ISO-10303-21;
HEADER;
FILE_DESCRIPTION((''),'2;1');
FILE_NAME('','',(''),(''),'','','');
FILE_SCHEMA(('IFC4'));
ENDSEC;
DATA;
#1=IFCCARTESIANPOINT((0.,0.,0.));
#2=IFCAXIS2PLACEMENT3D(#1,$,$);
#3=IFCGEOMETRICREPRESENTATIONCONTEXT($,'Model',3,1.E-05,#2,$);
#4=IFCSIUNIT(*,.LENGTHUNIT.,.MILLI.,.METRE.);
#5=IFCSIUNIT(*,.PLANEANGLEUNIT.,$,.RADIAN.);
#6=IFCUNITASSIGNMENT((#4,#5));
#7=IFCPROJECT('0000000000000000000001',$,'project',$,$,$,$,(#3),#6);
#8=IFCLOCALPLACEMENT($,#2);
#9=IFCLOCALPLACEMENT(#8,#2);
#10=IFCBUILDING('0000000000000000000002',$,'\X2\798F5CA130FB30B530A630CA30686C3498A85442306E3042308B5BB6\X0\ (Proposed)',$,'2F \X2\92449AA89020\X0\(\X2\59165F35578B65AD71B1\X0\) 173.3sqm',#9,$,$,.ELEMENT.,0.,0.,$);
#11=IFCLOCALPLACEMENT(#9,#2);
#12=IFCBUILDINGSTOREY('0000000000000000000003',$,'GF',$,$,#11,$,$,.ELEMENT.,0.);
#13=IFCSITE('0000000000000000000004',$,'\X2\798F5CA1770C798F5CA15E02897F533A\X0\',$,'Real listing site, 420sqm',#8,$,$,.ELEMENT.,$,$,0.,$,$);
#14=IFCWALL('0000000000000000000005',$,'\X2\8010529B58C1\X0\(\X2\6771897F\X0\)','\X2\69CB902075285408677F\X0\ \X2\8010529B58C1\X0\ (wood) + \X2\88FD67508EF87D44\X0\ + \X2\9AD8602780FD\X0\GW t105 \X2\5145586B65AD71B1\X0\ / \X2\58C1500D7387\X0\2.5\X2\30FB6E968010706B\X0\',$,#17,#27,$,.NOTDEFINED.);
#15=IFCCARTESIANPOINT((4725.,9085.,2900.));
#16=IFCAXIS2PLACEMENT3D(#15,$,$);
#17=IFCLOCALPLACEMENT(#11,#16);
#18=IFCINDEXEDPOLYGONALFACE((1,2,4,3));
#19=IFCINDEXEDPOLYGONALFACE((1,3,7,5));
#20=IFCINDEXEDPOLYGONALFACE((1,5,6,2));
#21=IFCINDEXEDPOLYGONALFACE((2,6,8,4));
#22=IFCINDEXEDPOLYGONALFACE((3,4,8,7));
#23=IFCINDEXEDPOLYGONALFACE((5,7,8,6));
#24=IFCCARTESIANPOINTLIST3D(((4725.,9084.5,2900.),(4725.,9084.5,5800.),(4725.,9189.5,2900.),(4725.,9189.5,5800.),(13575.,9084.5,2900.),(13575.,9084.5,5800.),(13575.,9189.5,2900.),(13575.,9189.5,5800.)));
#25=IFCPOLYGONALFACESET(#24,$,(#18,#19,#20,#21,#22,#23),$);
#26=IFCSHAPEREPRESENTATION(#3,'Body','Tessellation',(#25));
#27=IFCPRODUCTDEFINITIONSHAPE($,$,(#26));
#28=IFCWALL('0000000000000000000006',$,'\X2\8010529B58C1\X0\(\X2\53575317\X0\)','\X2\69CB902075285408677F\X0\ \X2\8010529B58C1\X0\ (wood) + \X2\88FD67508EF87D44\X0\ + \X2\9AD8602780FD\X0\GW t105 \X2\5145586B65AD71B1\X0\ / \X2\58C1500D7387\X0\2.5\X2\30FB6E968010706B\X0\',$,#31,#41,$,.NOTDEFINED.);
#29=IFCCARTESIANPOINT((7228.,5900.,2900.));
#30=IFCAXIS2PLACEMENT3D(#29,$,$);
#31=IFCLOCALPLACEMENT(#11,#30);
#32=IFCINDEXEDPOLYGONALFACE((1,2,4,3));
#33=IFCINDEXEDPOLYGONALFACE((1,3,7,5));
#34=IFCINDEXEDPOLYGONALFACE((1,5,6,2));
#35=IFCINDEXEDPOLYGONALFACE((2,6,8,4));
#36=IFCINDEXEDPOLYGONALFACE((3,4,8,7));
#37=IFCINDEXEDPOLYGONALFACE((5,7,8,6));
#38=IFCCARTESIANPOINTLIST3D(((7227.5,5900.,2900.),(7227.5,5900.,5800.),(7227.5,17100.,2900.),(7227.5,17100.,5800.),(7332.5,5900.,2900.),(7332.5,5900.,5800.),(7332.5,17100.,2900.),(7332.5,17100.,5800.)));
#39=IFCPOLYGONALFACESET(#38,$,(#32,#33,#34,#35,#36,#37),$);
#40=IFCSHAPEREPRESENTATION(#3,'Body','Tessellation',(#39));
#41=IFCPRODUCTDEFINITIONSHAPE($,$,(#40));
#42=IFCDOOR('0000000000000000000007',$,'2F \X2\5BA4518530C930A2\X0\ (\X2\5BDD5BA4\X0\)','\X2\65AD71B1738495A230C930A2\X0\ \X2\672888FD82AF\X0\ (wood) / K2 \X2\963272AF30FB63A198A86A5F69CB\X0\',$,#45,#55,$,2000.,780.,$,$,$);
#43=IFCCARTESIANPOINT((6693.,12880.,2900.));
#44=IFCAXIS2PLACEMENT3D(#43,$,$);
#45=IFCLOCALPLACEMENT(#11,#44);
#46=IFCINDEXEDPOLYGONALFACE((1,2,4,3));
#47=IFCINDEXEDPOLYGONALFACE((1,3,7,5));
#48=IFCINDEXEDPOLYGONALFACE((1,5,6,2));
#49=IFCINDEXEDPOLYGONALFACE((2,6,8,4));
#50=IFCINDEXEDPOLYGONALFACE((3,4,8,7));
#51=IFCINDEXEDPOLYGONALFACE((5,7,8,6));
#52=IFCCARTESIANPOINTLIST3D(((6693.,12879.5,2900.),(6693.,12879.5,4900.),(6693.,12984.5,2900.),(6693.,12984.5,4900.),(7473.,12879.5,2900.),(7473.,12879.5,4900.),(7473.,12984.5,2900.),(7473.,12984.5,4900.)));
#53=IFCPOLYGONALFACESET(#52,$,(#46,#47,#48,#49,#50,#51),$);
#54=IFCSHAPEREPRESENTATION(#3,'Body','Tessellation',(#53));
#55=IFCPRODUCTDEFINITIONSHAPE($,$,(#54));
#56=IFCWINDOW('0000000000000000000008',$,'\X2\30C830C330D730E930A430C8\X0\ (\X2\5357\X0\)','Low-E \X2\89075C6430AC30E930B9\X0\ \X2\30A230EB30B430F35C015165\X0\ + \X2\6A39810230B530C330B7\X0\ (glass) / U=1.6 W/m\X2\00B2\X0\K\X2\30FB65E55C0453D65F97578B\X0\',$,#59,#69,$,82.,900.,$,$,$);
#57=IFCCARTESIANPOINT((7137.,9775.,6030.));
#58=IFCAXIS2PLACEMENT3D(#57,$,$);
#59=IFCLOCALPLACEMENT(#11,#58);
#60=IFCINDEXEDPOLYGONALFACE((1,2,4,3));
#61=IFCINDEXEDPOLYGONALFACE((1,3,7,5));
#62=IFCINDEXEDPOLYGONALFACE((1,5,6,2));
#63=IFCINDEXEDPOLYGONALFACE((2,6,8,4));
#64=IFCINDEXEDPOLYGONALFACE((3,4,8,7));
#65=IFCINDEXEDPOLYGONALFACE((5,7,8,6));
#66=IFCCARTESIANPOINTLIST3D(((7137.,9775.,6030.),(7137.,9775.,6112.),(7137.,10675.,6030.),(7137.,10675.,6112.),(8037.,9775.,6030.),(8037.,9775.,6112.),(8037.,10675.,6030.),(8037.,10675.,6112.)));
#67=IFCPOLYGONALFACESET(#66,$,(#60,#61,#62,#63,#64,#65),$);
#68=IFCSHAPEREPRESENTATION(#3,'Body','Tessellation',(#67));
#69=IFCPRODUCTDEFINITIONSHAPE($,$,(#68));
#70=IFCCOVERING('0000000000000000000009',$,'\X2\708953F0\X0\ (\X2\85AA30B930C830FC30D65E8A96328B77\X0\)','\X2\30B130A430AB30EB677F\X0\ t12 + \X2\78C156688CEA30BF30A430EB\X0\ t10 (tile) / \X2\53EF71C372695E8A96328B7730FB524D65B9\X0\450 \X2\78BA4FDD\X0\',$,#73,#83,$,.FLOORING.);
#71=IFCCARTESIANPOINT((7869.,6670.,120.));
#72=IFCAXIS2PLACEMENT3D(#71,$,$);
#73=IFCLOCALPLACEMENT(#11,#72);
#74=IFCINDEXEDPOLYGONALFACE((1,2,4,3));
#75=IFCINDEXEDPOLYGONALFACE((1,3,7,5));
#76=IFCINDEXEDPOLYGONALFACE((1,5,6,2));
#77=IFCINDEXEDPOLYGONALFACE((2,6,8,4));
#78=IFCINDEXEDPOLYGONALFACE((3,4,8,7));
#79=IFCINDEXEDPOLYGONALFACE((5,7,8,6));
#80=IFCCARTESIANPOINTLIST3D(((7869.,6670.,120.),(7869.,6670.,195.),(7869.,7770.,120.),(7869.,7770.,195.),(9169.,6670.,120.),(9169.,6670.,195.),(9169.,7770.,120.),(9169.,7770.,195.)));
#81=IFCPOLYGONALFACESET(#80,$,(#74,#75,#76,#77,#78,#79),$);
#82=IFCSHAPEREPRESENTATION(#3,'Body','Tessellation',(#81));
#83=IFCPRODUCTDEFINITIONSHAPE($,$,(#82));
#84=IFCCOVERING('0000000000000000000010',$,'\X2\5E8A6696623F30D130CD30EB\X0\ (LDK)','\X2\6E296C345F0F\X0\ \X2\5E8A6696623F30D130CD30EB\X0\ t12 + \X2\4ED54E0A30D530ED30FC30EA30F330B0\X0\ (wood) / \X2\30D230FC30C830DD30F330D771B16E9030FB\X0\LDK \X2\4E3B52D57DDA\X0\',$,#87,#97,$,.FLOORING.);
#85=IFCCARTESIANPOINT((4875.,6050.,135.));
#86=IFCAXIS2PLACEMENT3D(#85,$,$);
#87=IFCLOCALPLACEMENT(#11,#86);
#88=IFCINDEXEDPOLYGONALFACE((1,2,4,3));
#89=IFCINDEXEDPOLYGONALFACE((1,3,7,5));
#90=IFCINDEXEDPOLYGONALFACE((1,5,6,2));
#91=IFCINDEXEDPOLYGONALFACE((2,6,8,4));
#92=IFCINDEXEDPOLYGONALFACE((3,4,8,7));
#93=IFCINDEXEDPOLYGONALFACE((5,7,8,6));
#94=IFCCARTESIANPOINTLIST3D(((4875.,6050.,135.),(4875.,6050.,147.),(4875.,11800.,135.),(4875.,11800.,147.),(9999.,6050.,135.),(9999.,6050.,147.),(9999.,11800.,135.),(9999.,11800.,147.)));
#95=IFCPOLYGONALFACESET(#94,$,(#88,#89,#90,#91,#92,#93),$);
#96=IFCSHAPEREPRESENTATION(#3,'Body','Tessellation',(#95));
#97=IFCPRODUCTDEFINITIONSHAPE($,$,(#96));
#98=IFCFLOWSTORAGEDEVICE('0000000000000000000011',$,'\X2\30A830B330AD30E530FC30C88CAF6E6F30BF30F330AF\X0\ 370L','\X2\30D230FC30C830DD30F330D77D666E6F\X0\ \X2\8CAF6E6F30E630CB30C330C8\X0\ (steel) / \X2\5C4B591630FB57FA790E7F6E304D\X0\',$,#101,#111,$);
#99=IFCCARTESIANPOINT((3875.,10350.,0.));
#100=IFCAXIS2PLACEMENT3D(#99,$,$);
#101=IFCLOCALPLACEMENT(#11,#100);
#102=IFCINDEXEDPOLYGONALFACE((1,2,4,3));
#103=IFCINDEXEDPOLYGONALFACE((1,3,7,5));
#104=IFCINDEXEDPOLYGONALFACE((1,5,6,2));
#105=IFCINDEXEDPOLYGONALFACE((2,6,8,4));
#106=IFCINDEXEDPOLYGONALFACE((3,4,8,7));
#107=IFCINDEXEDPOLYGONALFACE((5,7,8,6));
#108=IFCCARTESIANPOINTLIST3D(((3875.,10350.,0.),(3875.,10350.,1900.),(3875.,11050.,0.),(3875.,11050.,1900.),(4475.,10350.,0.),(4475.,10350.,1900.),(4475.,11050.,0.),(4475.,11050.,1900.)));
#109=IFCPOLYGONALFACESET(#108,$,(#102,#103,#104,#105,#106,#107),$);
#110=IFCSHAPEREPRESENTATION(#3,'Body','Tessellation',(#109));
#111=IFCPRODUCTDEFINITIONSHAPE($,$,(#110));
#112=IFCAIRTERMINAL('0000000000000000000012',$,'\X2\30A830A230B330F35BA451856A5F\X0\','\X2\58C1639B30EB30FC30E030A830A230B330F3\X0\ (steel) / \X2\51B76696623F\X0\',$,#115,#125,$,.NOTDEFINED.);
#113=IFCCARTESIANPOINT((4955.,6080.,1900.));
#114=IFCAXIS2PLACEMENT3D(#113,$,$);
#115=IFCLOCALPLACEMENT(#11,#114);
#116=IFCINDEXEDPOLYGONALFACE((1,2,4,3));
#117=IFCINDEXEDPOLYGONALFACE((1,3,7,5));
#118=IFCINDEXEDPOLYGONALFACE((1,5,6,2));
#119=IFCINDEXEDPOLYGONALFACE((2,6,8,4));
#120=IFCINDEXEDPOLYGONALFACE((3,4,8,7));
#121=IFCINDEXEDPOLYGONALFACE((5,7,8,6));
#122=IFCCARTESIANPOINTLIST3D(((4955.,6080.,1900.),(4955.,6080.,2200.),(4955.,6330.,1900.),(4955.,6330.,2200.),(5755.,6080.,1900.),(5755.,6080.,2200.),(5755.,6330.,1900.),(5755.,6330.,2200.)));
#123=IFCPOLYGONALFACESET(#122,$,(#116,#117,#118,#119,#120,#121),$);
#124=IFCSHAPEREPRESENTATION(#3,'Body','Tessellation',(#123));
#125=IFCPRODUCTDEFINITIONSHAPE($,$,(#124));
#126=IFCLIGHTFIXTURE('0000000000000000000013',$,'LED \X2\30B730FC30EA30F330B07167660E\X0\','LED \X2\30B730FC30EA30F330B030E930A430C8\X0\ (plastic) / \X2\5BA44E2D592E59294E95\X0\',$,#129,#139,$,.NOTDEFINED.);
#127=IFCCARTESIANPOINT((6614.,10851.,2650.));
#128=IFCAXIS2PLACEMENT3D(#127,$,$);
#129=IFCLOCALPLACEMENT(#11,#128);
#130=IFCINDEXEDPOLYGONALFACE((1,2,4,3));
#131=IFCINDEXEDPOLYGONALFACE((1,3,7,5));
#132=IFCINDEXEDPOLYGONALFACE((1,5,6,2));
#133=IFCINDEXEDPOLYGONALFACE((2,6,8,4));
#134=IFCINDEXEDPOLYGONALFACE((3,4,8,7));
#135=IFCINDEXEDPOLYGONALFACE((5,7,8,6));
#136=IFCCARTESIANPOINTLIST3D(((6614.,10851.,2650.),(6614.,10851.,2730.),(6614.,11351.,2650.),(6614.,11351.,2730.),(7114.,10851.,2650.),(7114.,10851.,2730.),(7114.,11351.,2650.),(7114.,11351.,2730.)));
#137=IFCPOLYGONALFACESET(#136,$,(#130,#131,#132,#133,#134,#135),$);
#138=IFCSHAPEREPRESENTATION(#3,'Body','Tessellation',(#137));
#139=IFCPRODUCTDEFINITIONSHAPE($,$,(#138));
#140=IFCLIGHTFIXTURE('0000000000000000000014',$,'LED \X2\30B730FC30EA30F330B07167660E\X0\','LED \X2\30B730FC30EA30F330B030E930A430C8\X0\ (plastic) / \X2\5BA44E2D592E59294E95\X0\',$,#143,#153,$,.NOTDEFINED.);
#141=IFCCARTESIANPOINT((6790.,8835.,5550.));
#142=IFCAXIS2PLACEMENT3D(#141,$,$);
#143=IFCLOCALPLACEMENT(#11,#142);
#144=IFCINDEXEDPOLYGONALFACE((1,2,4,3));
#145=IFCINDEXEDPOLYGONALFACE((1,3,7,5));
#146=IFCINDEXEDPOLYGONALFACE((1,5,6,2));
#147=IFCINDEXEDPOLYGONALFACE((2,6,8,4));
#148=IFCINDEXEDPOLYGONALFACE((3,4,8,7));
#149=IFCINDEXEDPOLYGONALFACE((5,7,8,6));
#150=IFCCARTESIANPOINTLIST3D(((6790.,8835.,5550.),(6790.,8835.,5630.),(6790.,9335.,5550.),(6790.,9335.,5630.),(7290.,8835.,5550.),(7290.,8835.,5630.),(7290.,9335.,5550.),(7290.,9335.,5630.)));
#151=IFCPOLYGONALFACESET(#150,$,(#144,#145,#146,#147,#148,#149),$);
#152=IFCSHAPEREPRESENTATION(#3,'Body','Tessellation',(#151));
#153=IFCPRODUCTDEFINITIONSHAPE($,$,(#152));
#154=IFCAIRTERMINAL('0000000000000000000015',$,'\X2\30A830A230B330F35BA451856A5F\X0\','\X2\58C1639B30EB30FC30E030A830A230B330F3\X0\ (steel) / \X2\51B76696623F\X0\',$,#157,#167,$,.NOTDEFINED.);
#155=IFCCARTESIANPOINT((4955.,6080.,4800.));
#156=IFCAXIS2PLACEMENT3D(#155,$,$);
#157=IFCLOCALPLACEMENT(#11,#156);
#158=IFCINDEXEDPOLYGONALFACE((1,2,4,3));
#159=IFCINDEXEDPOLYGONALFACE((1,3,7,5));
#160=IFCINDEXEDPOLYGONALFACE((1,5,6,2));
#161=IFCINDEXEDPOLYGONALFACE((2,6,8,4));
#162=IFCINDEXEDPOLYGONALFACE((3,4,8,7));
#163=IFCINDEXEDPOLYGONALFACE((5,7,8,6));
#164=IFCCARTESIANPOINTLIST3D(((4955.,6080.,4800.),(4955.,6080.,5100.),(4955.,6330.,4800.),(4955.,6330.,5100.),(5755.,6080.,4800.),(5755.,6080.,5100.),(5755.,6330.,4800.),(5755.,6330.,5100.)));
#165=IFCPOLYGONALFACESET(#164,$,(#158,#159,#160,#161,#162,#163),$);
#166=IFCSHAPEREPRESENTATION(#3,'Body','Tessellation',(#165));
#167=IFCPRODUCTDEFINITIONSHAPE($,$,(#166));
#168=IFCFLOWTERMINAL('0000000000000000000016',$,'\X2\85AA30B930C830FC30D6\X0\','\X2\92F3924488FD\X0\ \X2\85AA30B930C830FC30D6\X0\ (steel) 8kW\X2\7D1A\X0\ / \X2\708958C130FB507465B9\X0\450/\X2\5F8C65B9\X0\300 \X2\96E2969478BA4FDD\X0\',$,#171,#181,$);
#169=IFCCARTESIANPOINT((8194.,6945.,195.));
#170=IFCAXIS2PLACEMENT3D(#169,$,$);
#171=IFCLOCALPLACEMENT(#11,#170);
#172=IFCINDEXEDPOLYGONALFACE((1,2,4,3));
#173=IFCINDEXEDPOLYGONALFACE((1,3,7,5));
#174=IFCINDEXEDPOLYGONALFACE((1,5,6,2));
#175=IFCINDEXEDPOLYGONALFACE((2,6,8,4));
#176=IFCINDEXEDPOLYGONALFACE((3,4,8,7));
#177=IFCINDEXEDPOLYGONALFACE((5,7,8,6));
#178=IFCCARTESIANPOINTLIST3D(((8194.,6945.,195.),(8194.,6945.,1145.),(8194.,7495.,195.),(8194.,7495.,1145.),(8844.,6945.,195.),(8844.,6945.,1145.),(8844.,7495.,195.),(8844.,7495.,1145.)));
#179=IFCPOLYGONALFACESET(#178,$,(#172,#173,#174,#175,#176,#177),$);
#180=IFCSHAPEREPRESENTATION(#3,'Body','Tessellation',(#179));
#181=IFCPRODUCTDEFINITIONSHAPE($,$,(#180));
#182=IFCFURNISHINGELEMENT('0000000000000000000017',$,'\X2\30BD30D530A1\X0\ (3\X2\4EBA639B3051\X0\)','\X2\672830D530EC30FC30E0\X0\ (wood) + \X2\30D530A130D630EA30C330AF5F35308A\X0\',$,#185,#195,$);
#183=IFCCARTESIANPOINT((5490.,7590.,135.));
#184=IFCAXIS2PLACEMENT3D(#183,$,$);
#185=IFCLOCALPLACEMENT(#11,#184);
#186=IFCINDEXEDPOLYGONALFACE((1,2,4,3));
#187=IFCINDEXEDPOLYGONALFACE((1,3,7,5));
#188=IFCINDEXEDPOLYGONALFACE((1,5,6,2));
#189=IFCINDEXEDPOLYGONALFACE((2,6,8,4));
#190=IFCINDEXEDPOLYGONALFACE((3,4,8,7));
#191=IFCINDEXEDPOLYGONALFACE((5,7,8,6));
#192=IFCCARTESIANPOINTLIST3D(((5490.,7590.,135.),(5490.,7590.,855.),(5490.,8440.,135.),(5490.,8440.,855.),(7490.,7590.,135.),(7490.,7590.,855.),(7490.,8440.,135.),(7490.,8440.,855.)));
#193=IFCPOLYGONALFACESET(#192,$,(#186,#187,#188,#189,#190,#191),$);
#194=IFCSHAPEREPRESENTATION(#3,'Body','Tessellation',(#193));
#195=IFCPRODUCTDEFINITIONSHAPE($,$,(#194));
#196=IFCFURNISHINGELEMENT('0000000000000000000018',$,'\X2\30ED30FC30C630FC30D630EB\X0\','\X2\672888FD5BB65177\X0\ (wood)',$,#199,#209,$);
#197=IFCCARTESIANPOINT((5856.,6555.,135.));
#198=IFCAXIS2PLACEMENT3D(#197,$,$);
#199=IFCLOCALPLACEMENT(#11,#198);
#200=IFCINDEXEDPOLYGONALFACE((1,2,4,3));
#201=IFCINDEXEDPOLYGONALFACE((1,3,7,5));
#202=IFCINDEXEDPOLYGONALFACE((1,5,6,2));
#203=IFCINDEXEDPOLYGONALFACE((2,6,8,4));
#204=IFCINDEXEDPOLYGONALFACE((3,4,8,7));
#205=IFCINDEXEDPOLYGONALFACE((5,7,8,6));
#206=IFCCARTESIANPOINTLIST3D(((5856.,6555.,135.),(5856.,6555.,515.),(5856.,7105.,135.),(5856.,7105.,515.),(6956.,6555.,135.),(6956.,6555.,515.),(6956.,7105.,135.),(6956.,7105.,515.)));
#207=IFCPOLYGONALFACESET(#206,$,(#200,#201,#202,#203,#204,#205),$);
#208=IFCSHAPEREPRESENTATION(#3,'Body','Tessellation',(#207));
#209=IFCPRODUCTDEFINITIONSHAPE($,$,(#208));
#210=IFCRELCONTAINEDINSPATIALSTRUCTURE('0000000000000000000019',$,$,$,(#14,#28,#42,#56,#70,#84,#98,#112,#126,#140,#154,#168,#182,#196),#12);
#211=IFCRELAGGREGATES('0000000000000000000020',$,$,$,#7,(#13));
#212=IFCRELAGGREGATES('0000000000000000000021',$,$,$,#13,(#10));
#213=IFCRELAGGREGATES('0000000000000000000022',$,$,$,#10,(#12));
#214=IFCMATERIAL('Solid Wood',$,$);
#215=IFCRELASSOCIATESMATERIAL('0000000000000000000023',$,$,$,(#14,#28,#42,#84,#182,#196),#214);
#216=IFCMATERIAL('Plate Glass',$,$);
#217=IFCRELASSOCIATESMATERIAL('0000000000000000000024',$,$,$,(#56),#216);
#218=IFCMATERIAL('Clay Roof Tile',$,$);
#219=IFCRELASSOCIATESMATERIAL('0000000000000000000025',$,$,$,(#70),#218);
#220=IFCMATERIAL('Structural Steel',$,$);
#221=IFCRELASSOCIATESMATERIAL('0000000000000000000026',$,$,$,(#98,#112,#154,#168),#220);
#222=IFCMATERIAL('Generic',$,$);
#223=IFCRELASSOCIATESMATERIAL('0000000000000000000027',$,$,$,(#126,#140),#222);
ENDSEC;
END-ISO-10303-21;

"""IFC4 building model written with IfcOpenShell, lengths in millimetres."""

from ifc_helpers import new_model, si_unit, frame, frame_2d, origin, place, context, project, spatial, rectangle, extrude, material, element, fill, save


model = new_model("IFC4")

# Units and contexts
model_context = context("Model", 3, precision=1e-05, world=origin())
ifc_project = project(units=[si_unit("LENGTHUNIT", "METRE", prefix="MILLI"), si_unit("PLANEANGLEUNIT", "RADIAN")], contexts=[model_context])

# Site, building, storey
site_placement = place(None, origin())
site = spatial("IfcSite", under=ifc_project, at=site_placement, Name="福岡県福岡市西区", ObjectType="Real listing site, 420sqm", CompositionType="ELEMENT", RefElevation=0.0)
building_placement = place(site_placement, origin())
building = spatial("IfcBuilding", under=site, at=building_placement, Name="福岡・サウナと水風呂のある家 (Proposed)", ObjectType="2F 鉄骨造(外張型断熱) 173.3sqm", CompositionType="ELEMENT", ElevationOfRefHeight=0.0, ElevationOfTerrain=0.0)
storey_placement = place(building_placement, origin())
storey = spatial("IfcBuildingStorey", under=building, at=storey_placement, Name="GF", CompositionType="ELEMENT", Elevation=0.0)

# Shared definitions
ifc_material_1 = material(Name="Solid Wood")

# Wall
wall_1_placement = place(storey_placement, frame((4725.0, 9085.0, 2900.0)))
element("IfcWall", 1, at=wall_1_placement, inside=storey, material=ifc_material_1, Name="耐力壁(東西)", Description="構造用合板 耐力壁 (wood) + 製材軸組 + 高性能GW t105 充填断熱 / 壁倍率2.5・準耐火", PredefinedType="NOTDEFINED", context=model_context, shape_type="SweptSolid", body=[
    extrude(rectangle(XDim=8850.0, YDim=105.0, at=frame_2d((4425.0, 52.0))), frame((4725.0, 9085.0, 2900.0)), (0.0, 0.0, 1.0), 2900.0),
])

# Wall, opening, door
wall_2_placement = place(storey_placement, frame((7228.0, 5900.0, 2900.0)))
wall_2 = element("IfcWall", 2, at=wall_2_placement, inside=storey, material=ifc_material_1, Name="耐力壁(南北)", Description="構造用合板 耐力壁 (wood) + 製材軸組 + 高性能GW t105 充填断熱 / 壁倍率2.5・準耐火", PredefinedType="NOTDEFINED", context=model_context, shape_type="SweptSolid", body=[
    extrude(rectangle(XDim=105.0, YDim=11200.0, at=frame_2d((52.0, 5600.0))), frame((7228.0, 5900.0, 2900.0)), (0.0, 0.0, 1.0), 2900.0),
])
opening_placement = place(storey_placement, frame((6693.0, 12880.0, 2900.0)))
opening = element("IfcOpeningElement", 3, at=opening_placement, cuts=wall_2, PredefinedType="NOTDEFINED", context=model_context, shape_type="SweptSolid", body=[
    extrude(rectangle(XDim=780.0, YDim=105.0, at=frame_2d((390.0, 52.0))), frame((6693.0, 12880.0, 2900.0)), (0.0, 0.0, 1.0), 2000.0),
])
door_placement = place(storey_placement, frame((6693.0, 12880.0, 2900.0)))
door = element("IfcDoor", 4, at=door_placement, inside=storey, material=ifc_material_1, Name="2F 室内ドア (寝室)", Description="断熱玄関ドア 木製芯 (wood) / K2 防犯・採風機構", OverallHeight=2000.0, OverallWidth=780.0, context=model_context, shape_type="SweptSolid", body=[
    extrude(rectangle(XDim=780.0, YDim=105.0, at=frame_2d((390.0, 52.0))), frame((6693.0, 12880.0, 2900.0)), (0.0, 0.0, 1.0), 2000.0),
])
fill(opening, door)

# Window
ifc_material_2 = material(Name="Plate Glass")
window_placement = place(storey_placement, frame((7137.0, 9775.0, 6030.0)))
element("IfcWindow", 5, at=window_placement, inside=storey, material=ifc_material_2, Name="トップライト (南)", Description="Low-E 複層ガラス アルゴン封入 + 樹脂サッシ (glass) / U=1.6 W/m²K・日射取得型", OverallHeight=82.0, OverallWidth=900.0, context=model_context, shape_type="SweptSolid", body=[
    extrude(rectangle(XDim=900.0, YDim=900.0, at=frame_2d((450.0, 450.0))), frame((7137.0, 9775.0, 6030.0)), (0.0, 0.0, 1.0), 82.0),
])

# Coverings
ifc_material_3 = material(Name="Clay Roof Tile")
covering_1_placement = place(storey_placement, frame((7869.0, 6670.0, 120.0)))
element("IfcCovering", 6, at=covering_1_placement, inside=storey, material=ifc_material_3, Name="炉台 (薪ストーブ床防護)", Description="ケイカル板 t12 + 磁器質タイル t10 (tile) / 可燃物床防護・前方450 確保", PredefinedType="FLOORING", context=model_context, shape_type="SweptSolid", body=[
    extrude(rectangle(XDim=1300.0, YDim=1100.0, at=frame_2d((650.0, 550.0))), frame((7869.0, 6670.0, 120.0)), (0.0, 0.0, 1.0), 75.0),
])
covering_2_placement = place(storey_placement, frame((4875.0, 6050.0, 135.0)))
element("IfcCovering", 7, at=covering_2_placement, inside=storey, material=ifc_material_1, Name="床暖房パネル (LDK)", Description="温水式 床暖房パネル t12 + 仕上フローリング (wood) / ヒートポンプ熱源・LDK 主動線", PredefinedType="FLOORING", context=model_context, shape_type="SweptSolid", body=[
    extrude(rectangle(XDim=5124.0, YDim=5750.0, at=frame_2d((2562.0, 2875.0))), frame((4875.0, 6050.0, 135.0)), (0.0, 0.0, 1.0), 12.0),
])

# Flow storage device
ifc_material_4 = material(Name="Structural Steel")
flow_storage_device_placement = place(storey_placement, frame((3875.0, 10350.0, 0.0)))
element("IfcFlowStorageDevice", 8, at=flow_storage_device_placement, inside=storey, material=ifc_material_4, Name="エコキュート貯湯タンク 370L", Description="ヒートポンプ給湯 貯湯ユニット (steel) / 屋外・基礎置き", context=model_context, shape_type="SweptSolid", body=[
    extrude(rectangle(XDim=600.0, YDim=700.0, at=frame_2d((300.0, 350.0))), frame((3875.0, 10350.0, 0.0)), (0.0, 0.0, 1.0), 1900.0),
])

# Air terminal
air_terminal_1_placement = place(storey_placement, frame((4955.0, 6080.0, 1900.0)))
element("IfcAirTerminal", 9, at=air_terminal_1_placement, inside=storey, material=ifc_material_4, Name="エアコン室内機", Description="壁掛ルームエアコン (steel) / 冷暖房", PredefinedType="NOTDEFINED", context=model_context, shape_type="SweptSolid", body=[
    extrude(rectangle(XDim=800.0, YDim=250.0, at=frame_2d((400.0, 125.0))), frame((4955.0, 6080.0, 1900.0)), (0.0, 0.0, 1.0), 300.0),
])

# Light fixtures
ifc_material_5 = material(Name="Generic")
light_fixture_1_placement = place(storey_placement, frame((6614.0, 10851.0, 2650.0)))
element("IfcLightFixture", 10, at=light_fixture_1_placement, inside=storey, material=ifc_material_5, Name="LED シーリング照明", Description="LED シーリングライト (plastic) / 室中央天井", PredefinedType="NOTDEFINED", context=model_context, shape_type="SweptSolid", body=[
    extrude(rectangle(XDim=500.0, YDim=500.0, at=frame_2d((250.0, 250.0))), frame((6614.0, 10851.0, 2650.0)), (0.0, 0.0, 1.0), 80.0),
])
light_fixture_2_placement = place(storey_placement, frame((6790.0, 8835.0, 5550.0)))
element("IfcLightFixture", 11, at=light_fixture_2_placement, inside=storey, material=ifc_material_5, Name="LED シーリング照明", Description="LED シーリングライト (plastic) / 室中央天井", PredefinedType="NOTDEFINED", context=model_context, shape_type="SweptSolid", body=[
    extrude(rectangle(XDim=500.0, YDim=500.0, at=frame_2d((250.0, 250.0))), frame((6790.0, 8835.0, 5550.0)), (0.0, 0.0, 1.0), 80.0),
])

# Air terminal
air_terminal_2_placement = place(storey_placement, frame((4955.0, 6080.0, 4800.0)))
element("IfcAirTerminal", 12, at=air_terminal_2_placement, inside=storey, material=ifc_material_4, Name="エアコン室内機", Description="壁掛ルームエアコン (steel) / 冷暖房", PredefinedType="NOTDEFINED", context=model_context, shape_type="SweptSolid", body=[
    extrude(rectangle(XDim=800.0, YDim=250.0, at=frame_2d((400.0, 125.0))), frame((4955.0, 6080.0, 4800.0)), (0.0, 0.0, 1.0), 300.0),
])

# Flow terminal
flow_terminal_placement = place(storey_placement, frame((8194.0, 6945.0, 195.0)))
element("IfcFlowTerminal", 13, at=flow_terminal_placement, inside=storey, material=ifc_material_4, Name="薪ストーブ", Description="鋳鉄製 薪ストーブ (steel) 8kW級 / 炉壁・側方450/後方300 離隔確保", context=model_context, shape_type="SweptSolid", body=[
    extrude(rectangle(XDim=650.0, YDim=550.0, at=frame_2d((325.0, 275.0))), frame((8194.0, 6945.0, 195.0)), (0.0, 0.0, 1.0), 950.0),
])

# Furnishing elements
furnishing_1_placement = place(storey_placement, frame((5490.0, 7590.0, 135.0)))
element("IfcFurnishingElement", 14, at=furnishing_1_placement, inside=storey, material=ifc_material_1, Name="ソファ (3人掛け)", Description="木フレーム (wood) + ファブリック張り", context=model_context, shape_type="SweptSolid", body=[
    extrude(rectangle(XDim=2000.0, YDim=850.0, at=frame_2d((1000.0, 425.0))), frame((5490.0, 7590.0, 135.0)), (0.0, 0.0, 1.0), 720.0),
])
furnishing_2_placement = place(storey_placement, frame((5856.0, 6555.0, 135.0)))
element("IfcFurnishingElement", 15, at=furnishing_2_placement, inside=storey, material=ifc_material_1, Name="ローテーブル", Description="木製家具 (wood)", context=model_context, shape_type="SweptSolid", body=[
    extrude(rectangle(XDim=1100.0, YDim=550.0, at=frame_2d((550.0, 275.0))), frame((5856.0, 6555.0, 135.0)), (0.0, 0.0, 1.0), 380.0),
])

save(model, "model.ifc")
